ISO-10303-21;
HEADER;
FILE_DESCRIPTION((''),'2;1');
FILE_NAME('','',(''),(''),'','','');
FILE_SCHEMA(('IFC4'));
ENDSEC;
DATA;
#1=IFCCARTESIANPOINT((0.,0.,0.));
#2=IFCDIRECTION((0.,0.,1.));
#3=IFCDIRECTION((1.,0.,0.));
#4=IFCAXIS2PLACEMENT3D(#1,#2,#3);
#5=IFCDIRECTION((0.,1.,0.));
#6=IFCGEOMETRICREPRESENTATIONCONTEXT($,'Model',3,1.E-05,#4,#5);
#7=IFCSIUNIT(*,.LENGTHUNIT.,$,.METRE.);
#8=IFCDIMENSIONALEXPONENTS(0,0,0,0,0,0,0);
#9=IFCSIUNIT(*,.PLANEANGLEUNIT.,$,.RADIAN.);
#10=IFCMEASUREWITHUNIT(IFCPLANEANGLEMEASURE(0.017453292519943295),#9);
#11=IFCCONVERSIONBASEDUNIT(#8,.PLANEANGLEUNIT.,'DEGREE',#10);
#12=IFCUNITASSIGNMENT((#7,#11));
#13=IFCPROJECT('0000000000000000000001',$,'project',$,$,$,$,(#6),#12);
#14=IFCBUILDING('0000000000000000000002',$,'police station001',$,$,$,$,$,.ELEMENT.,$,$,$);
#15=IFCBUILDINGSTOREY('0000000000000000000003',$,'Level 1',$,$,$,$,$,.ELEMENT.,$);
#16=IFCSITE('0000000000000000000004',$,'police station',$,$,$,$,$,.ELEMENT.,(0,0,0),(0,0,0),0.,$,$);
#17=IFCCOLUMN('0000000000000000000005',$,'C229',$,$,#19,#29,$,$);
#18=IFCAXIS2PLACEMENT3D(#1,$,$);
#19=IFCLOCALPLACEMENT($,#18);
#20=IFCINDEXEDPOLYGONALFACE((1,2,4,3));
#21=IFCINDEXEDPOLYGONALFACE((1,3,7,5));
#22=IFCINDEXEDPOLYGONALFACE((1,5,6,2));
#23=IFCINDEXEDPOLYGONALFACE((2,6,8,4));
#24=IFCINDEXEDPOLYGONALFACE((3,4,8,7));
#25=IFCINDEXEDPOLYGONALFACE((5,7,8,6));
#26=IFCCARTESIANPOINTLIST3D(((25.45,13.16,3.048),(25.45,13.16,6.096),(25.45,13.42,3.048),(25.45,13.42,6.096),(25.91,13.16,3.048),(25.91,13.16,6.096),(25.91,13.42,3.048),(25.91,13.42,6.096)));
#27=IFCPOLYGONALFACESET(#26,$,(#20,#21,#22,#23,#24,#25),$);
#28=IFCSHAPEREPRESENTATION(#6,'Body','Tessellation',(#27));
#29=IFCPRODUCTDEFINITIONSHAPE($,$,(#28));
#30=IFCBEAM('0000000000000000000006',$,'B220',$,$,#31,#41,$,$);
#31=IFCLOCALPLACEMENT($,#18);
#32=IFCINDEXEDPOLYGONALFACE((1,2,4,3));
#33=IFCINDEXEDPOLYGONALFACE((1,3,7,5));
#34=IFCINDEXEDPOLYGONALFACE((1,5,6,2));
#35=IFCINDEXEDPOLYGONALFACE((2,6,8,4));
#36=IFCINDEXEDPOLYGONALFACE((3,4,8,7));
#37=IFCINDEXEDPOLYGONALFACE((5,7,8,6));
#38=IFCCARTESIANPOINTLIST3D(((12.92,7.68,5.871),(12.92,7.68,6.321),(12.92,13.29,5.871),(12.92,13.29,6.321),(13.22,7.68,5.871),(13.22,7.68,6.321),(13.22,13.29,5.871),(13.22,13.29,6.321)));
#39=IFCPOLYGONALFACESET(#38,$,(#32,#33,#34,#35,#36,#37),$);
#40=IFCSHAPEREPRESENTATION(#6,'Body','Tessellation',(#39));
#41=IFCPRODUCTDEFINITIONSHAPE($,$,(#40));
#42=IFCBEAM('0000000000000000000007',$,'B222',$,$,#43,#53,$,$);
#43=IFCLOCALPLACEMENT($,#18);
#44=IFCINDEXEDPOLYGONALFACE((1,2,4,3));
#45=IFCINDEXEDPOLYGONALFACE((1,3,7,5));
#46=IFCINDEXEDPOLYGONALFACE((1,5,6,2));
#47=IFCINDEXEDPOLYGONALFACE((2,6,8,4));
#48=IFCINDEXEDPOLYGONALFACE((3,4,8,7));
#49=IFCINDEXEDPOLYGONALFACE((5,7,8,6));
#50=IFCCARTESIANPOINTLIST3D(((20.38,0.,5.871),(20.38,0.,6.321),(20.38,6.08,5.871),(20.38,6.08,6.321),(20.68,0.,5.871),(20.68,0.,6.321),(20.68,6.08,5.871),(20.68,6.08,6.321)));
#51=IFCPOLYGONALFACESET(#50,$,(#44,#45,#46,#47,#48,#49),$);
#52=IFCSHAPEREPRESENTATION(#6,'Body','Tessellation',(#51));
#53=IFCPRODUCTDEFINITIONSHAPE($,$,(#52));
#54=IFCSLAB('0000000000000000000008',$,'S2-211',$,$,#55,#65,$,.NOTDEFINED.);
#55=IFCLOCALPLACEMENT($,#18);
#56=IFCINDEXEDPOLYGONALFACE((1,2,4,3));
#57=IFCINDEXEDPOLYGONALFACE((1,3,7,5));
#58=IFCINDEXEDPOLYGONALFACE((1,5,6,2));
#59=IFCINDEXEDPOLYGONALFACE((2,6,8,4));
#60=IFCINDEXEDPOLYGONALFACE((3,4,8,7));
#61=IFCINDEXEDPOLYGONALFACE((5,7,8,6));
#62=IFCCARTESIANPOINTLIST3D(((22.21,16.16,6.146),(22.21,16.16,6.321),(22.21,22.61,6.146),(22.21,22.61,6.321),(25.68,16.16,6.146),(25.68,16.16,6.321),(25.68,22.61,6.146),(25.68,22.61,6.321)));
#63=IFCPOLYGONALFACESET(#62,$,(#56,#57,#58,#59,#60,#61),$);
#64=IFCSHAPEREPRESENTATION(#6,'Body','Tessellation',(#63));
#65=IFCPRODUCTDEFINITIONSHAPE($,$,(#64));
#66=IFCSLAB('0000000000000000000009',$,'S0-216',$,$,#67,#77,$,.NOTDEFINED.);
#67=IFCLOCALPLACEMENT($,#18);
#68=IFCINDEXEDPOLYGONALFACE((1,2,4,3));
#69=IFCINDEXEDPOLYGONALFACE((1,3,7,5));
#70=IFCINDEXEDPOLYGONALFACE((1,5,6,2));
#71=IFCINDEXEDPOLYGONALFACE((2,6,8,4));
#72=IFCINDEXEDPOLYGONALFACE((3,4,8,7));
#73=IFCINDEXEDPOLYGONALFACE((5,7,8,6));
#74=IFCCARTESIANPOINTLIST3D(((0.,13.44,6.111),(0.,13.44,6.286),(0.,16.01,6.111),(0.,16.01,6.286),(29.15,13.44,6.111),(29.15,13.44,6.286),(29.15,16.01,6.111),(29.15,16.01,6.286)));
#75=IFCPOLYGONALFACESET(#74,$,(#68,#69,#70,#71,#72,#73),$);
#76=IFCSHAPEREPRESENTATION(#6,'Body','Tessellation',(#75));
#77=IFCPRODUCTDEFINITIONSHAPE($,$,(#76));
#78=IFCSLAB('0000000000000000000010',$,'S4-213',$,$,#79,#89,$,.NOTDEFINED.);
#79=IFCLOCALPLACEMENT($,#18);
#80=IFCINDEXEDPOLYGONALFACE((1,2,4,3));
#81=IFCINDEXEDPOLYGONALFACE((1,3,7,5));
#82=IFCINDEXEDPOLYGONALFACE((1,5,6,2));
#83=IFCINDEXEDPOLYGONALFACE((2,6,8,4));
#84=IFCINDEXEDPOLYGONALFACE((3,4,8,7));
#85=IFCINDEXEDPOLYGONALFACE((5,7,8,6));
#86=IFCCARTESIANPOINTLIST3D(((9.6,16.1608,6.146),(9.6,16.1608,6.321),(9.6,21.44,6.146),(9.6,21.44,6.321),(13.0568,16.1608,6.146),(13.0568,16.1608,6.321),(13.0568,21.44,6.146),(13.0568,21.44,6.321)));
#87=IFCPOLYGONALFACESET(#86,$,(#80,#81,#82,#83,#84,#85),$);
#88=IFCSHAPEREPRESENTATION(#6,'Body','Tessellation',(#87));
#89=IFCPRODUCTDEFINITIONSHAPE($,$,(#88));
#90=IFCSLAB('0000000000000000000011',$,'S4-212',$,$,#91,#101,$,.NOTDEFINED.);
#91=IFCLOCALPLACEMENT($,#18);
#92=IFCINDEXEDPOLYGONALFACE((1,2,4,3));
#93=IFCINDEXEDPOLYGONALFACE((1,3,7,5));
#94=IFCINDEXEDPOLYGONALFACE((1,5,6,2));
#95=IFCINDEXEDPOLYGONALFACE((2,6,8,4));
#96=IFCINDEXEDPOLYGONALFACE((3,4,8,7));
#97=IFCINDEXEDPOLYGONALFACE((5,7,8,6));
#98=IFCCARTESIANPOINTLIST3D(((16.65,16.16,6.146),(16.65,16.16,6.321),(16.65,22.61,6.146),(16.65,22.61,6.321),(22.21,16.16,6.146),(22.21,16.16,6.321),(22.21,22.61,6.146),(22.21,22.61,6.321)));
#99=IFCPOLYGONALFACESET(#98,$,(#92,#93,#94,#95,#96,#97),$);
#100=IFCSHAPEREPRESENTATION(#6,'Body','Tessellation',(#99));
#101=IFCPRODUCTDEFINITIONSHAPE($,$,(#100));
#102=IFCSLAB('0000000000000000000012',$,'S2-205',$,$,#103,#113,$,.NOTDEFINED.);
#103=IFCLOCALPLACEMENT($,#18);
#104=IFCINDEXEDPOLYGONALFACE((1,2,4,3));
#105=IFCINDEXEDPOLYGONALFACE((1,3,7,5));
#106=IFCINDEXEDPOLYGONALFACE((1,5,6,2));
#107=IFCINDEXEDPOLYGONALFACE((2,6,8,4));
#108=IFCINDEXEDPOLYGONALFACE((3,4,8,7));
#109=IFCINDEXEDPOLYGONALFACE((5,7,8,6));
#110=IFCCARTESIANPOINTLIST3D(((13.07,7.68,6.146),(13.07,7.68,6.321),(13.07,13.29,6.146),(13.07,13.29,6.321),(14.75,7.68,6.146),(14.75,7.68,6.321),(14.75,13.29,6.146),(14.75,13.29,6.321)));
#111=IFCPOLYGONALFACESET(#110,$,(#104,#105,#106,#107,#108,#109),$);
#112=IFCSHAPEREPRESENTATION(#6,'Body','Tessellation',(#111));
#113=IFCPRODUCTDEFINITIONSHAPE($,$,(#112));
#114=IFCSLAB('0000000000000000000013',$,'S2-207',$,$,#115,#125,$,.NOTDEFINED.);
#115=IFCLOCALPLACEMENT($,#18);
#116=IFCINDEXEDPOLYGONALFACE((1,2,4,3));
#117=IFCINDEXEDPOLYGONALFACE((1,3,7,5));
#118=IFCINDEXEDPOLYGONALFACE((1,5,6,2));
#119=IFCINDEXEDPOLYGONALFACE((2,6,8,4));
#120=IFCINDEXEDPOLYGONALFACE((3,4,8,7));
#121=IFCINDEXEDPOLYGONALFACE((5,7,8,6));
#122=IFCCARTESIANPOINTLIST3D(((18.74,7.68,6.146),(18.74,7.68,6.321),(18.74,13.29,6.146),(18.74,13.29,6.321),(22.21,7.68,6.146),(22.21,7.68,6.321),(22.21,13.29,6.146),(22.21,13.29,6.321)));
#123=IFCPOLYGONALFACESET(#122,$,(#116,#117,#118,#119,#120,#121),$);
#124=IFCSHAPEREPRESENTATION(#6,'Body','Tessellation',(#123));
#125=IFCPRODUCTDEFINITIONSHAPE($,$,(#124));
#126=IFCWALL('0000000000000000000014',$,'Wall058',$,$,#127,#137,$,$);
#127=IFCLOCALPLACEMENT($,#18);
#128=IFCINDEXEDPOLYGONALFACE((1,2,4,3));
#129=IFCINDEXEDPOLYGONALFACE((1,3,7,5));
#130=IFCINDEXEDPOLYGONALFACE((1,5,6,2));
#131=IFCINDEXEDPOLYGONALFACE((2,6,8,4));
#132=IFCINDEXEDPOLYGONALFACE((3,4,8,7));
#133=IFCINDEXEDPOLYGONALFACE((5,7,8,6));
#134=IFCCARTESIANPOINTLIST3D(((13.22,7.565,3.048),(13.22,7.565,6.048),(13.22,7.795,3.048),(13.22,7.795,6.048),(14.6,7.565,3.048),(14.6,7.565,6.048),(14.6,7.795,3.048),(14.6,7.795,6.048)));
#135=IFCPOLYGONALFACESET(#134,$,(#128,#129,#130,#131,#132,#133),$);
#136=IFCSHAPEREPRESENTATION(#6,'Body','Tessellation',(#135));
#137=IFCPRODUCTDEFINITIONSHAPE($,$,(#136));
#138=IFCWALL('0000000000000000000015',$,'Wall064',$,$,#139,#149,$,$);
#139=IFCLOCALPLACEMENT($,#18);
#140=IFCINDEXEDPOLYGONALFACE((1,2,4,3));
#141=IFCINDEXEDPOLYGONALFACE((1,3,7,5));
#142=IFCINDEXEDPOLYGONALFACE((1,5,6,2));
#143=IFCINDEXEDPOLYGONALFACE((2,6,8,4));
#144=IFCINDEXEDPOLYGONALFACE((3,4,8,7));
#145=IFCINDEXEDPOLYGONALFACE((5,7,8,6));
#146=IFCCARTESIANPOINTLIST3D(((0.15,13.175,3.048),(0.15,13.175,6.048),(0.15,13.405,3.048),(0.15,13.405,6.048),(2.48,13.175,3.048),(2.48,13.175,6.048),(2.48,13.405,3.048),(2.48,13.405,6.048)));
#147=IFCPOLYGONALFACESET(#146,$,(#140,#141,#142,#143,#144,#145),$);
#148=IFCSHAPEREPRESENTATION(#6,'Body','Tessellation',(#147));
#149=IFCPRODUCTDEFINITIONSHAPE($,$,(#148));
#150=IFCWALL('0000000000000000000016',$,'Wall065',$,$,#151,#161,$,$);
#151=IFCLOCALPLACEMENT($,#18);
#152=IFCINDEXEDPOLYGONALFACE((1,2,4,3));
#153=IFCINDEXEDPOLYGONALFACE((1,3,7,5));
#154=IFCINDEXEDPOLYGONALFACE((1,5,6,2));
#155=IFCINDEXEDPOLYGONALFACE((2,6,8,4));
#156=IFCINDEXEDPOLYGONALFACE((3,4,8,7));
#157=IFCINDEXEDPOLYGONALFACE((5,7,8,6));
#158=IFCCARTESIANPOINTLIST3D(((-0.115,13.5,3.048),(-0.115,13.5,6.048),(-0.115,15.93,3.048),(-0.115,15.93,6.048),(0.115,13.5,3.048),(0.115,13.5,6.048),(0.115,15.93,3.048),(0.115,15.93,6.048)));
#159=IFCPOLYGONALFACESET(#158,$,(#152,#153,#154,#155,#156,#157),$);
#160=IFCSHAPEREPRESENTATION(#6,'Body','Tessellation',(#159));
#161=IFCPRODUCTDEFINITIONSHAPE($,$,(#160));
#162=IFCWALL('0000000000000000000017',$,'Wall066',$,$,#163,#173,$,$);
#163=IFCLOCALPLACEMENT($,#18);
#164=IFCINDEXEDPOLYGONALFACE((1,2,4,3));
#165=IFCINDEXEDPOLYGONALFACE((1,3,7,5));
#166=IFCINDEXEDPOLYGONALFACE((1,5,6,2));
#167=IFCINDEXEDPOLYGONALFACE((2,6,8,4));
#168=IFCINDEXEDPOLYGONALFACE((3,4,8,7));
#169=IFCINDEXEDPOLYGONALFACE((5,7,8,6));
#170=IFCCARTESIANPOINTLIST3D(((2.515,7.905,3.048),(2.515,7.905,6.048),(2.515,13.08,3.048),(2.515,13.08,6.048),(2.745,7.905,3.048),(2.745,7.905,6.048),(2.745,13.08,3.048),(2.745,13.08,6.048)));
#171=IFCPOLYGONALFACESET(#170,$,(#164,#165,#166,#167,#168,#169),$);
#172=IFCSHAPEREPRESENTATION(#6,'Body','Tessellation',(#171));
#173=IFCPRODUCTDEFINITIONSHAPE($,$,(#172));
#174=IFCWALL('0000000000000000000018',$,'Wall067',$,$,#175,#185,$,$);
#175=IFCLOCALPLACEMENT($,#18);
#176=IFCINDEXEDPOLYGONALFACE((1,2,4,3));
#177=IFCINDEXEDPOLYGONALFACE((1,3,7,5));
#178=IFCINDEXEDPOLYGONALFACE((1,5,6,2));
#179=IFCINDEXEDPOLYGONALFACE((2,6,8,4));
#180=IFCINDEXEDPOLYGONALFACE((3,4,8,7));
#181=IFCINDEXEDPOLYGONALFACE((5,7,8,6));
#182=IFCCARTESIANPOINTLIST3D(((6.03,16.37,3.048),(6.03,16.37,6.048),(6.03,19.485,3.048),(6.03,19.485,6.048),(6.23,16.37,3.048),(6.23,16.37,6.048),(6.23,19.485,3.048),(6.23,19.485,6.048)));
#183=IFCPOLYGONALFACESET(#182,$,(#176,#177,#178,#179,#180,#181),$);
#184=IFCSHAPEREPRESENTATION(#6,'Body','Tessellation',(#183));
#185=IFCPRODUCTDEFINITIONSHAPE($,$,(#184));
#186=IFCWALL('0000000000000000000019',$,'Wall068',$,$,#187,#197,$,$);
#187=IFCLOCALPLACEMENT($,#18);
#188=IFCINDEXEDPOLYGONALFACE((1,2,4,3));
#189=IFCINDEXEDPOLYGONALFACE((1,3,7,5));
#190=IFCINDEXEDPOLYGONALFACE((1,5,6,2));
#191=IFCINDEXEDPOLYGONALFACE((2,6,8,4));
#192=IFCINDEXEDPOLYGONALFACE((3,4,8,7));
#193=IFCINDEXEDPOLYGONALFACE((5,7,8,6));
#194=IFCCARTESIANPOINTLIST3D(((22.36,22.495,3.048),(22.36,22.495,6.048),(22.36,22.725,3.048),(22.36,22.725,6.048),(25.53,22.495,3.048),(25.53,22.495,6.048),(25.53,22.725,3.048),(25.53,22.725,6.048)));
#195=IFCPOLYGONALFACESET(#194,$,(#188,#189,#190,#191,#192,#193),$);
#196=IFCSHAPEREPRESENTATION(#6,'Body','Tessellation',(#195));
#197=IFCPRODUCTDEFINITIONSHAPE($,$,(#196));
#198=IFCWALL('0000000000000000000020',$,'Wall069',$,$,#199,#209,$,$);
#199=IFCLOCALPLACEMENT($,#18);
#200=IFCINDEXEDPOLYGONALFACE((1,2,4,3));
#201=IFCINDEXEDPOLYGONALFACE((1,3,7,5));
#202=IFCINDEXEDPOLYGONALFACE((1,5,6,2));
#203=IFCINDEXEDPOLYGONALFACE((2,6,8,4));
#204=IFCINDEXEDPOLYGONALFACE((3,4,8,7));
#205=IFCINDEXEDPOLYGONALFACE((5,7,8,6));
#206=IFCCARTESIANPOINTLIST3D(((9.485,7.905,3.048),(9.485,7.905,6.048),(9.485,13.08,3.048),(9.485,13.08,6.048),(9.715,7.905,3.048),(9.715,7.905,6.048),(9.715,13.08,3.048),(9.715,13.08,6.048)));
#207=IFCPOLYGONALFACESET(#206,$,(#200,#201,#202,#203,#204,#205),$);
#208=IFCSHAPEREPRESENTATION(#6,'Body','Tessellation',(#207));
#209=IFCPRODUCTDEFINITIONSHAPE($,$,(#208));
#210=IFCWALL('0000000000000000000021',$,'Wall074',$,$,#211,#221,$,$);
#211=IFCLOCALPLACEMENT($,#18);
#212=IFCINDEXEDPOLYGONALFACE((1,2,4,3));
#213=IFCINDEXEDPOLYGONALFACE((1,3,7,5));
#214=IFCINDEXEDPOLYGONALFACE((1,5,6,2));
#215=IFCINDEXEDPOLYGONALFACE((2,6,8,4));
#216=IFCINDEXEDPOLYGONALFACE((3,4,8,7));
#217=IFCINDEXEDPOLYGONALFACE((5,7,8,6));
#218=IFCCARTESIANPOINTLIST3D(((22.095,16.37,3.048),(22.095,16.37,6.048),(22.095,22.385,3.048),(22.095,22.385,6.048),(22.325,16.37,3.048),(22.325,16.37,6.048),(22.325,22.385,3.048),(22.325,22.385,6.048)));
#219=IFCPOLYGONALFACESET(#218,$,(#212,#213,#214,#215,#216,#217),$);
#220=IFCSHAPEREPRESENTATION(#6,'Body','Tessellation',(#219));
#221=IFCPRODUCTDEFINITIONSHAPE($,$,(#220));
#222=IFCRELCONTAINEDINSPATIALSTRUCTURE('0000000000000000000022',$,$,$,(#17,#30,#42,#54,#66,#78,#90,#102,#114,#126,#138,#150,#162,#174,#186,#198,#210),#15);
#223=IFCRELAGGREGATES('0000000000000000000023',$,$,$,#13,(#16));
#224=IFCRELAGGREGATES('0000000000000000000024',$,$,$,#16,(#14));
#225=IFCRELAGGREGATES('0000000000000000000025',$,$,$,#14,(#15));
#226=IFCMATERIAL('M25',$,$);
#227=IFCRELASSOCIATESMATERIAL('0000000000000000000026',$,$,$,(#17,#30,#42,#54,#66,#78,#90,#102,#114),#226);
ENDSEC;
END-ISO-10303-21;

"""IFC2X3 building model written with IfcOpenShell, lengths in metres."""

from ifc_helpers import new_model, entity, si_unit, converted_unit, direction, frame, frame_2d, origin_with_axes, place, context, project, spatial, rectangle, extrude, material, element, save


model = new_model("IFC2X3")

# Units and contexts
model_context = context("Model", 3, precision=1e-05, world=origin_with_axes(), true_north=direction((0.0, 1.0, 0.0)))
ifc_project = project(units=[si_unit("LENGTHUNIT", "METRE"), converted_unit("PLANEANGLEUNIT", "DEGREE", entity("IfcPlaneAngleMeasure", 0.017453292519943295), si_unit("PLANEANGLEUNIT", "RADIAN"), dimensions=[0, 0, 0, 0, 0, 0, 0])], contexts=[model_context])

# Site, building, storey
site = spatial("IfcSite", under=ifc_project, Name="police station", CompositionType="ELEMENT", RefLatitude=(0, 0, 0), RefLongitude=(0, 0, 0), RefElevation=0.0)
building = spatial("IfcBuilding", under=site, Name="police station001", CompositionType="ELEMENT")
storey = spatial("IfcBuildingStorey", under=building, Name="Level 1", CompositionType="ELEMENT")

# Column
ifc_material = material(Name="M25")
placement = place(None, origin_with_axes())
element("IfcColumn", 1, at=placement, inside=storey, material=ifc_material, Name="C229", context=model_context, shape_type="SweptSolid", body=[
    extrude(rectangle(XDim=0.46, YDim=0.26, at=frame_2d((0.0, 0.0), x_axis=(1.0, 0.0, 0.0))), frame((25.68, 13.29, 3.048), z_axis=(0.0, 0.0, 1.0), x_axis=(1.0, 0.0, 0.0)), (0.0, 0.0, 1.0), 3.048),
])

# Beams
element("IfcBeam", 2, at=placement, inside=storey, material=ifc_material, Name="B220", context=model_context, shape_type="SweptSolid", body=[
    extrude(rectangle(XDim=0.3, YDim=0.45, at=frame_2d((0.0, 0.0), x_axis=(0.0, 1.0, 0.0))), frame((13.07, 13.29, 6.096), z_axis=(0.0, -1.0, 0.0), x_axis=(0.0, 0.0, -1.0)), (0.0, 0.0, 1.0), 5.61),
])
element("IfcBeam", 3, at=placement, inside=storey, material=ifc_material, Name="B222", context=model_context, shape_type="SweptSolid", body=[
    extrude(rectangle(XDim=0.3, YDim=0.45, at=frame_2d((0.0, 0.0), x_axis=(0.0, 1.0, 0.0))), frame((20.53, 0.0, 6.096), z_axis=(0.0, 1.0, 0.0), x_axis=(0.0, 0.0, -1.0)), (0.0, 0.0, 1.0), 6.08),
])

# Slabs
element("IfcSlab", 4, at=placement, inside=storey, material=ifc_material, Name="S2-211", PredefinedType="NOTDEFINED", context=model_context, shape_type="SweptSolid", body=[
    extrude(rectangle(XDim=3.47, YDim=6.45, at=frame_2d((0.0, 0.0), x_axis=(1.0, 0.0, 0.0))), frame((23.945, 19.385, 6.146), z_axis=(0.0, 0.0, 1.0), x_axis=(1.0, 0.0, 0.0)), (0.0, 0.0, 1.0), 0.175),
])
element("IfcSlab", 5, at=placement, inside=storey, material=ifc_material, Name="S0-216", PredefinedType="NOTDEFINED", context=model_context, shape_type="SweptSolid", body=[
    extrude(rectangle(XDim=29.15, YDim=2.57, at=frame_2d((0.0, 0.0), x_axis=(1.0, 0.0, 0.0))), frame((14.575, 14.725, 6.111), z_axis=(0.0, 0.0, 1.0), x_axis=(1.0, 0.0, 0.0)), (0.0, 0.0, 1.0), 0.175),
])
element("IfcSlab", 6, at=placement, inside=storey, material=ifc_material, Name="S4-213", PredefinedType="NOTDEFINED", context=model_context, shape_type="SweptSolid", body=[
    extrude(rectangle(XDim=3.4568, YDim=5.2792, at=frame_2d((0.0, 0.0), x_axis=(1.0, 0.0, 0.0))), frame((11.3284, 18.8004, 6.146), z_axis=(0.0, 0.0, 1.0), x_axis=(1.0, 0.0, 0.0)), (0.0, 0.0, 1.0), 0.175),
])
element("IfcSlab", 7, at=placement, inside=storey, material=ifc_material, Name="S4-212", PredefinedType="NOTDEFINED", context=model_context, shape_type="SweptSolid", body=[
    extrude(rectangle(XDim=5.56, YDim=6.45, at=frame_2d((0.0, 0.0), x_axis=(1.0, 0.0, 0.0))), frame((19.43, 19.385, 6.146), z_axis=(0.0, 0.0, 1.0), x_axis=(1.0, 0.0, 0.0)), (0.0, 0.0, 1.0), 0.175),
])
element("IfcSlab", 8, at=placement, inside=storey, material=ifc_material, Name="S2-205", PredefinedType="NOTDEFINED", context=model_context, shape_type="SweptSolid", body=[
    extrude(rectangle(XDim=1.68, YDim=5.61, at=frame_2d((0.0, 0.0), x_axis=(1.0, 0.0, 0.0))), frame((13.91, 10.485, 6.146), z_axis=(0.0, 0.0, 1.0), x_axis=(1.0, 0.0, 0.0)), (0.0, 0.0, 1.0), 0.175),
])
element("IfcSlab", 9, at=placement, inside=storey, material=ifc_material, Name="S2-207", PredefinedType="NOTDEFINED", context=model_context, shape_type="SweptSolid", body=[
    extrude(rectangle(XDim=3.47, YDim=5.61, at=frame_2d((0.0, 0.0), x_axis=(1.0, 0.0, 0.0))), frame((20.475, 10.485, 6.146), z_axis=(0.0, 0.0, 1.0), x_axis=(1.0, 0.0, 0.0)), (0.0, 0.0, 1.0), 0.175),
])

# Walls
element("IfcWall", 10, at=placement, inside=storey, Name="Wall058", context=model_context, shape_type="SweptSolid", body=[
    extrude(rectangle(XDim=1.38, YDim=0.23, at=frame_2d((0.0, 0.0), x_axis=(1.0, 0.0, 0.0))), frame((13.91, 7.68, 3.048), z_axis=(0.0, 0.0, 1.0), x_axis=(1.0, 0.0, 0.0)), (0.0, 0.0, 1.0), 3.0),
])
element("IfcWall", 11, at=placement, inside=storey, Name="Wall064", context=model_context, shape_type="SweptSolid", body=[
    extrude(rectangle(XDim=2.33, YDim=0.23, at=frame_2d((0.0, 0.0), x_axis=(1.0, 0.0, 0.0))), frame((1.315, 13.29, 3.048), z_axis=(0.0, 0.0, 1.0), x_axis=(1.0, 0.0, 0.0)), (0.0, 0.0, 1.0), 3.0),
])
element("IfcWall", 12, at=placement, inside=storey, Name="Wall065", context=model_context, shape_type="SweptSolid", body=[
    extrude(rectangle(XDim=2.43, YDim=0.23, at=frame_2d((0.0, 0.0), x_axis=(0.0, -1.0, 0.0))), frame((0.0, 14.715, 3.048), z_axis=(0.0, 0.0, 1.0), x_axis=(1.0, 0.0, 0.0)), (0.0, 0.0, 1.0), 3.0),
])
element("IfcWall", 13, at=placement, inside=storey, Name="Wall066", context=model_context, shape_type="SweptSolid", body=[
    extrude(rectangle(XDim=5.175, YDim=0.23, at=frame_2d((0.0, 0.0), x_axis=(0.0, -1.0, 0.0))), frame((2.63, 10.4925, 3.048), z_axis=(0.0, 0.0, 1.0), x_axis=(1.0, 0.0, 0.0)), (0.0, 0.0, 1.0), 3.0),
])
element("IfcWall", 14, at=placement, inside=storey, Name="Wall067", context=model_context, shape_type="SweptSolid", body=[
    extrude(rectangle(XDim=3.115, YDim=0.2, at=frame_2d((0.0, 0.0), x_axis=(0.0, -1.0, 0.0))), frame((6.13, 17.9275, 3.048), z_axis=(0.0, 0.0, 1.0), x_axis=(1.0, 0.0, 0.0)), (0.0, 0.0, 1.0), 3.0),
])
element("IfcWall", 15, at=placement, inside=storey, Name="Wall068", context=model_context, shape_type="SweptSolid", body=[
    extrude(rectangle(XDim=3.17, YDim=0.23, at=frame_2d((0.0, 0.0), x_axis=(-1.0, 0.0, 0.0))), frame((23.945, 22.61, 3.048), z_axis=(0.0, 0.0, 1.0), x_axis=(1.0, 0.0, 0.0)), (0.0, 0.0, 1.0), 3.0),
])
element("IfcWall", 16, at=placement, inside=storey, Name="Wall069", context=model_context, shape_type="SweptSolid", body=[
    extrude(rectangle(XDim=5.175, YDim=0.23, at=frame_2d((0.0, 0.0), x_axis=(0.0, -1.0, 0.0))), frame((9.6, 10.4925, 3.048), z_axis=(0.0, 0.0, 1.0), x_axis=(1.0, 0.0, 0.0)), (0.0, 0.0, 1.0), 3.0),
])
element("IfcWall", 17, at=placement, inside=storey, Name="Wall074", context=model_context, shape_type="SweptSolid", body=[
    extrude(rectangle(XDim=6.015, YDim=0.23, at=frame_2d((0.0, 0.0), x_axis=(0.0, -1.0, 0.0))), frame((22.21, 19.3775, 3.048), z_axis=(0.0, 0.0, 1.0), x_axis=(1.0, 0.0, 0.0)), (0.0, 0.0, 1.0), 3.0),
])

save(model, "model.ifc")
